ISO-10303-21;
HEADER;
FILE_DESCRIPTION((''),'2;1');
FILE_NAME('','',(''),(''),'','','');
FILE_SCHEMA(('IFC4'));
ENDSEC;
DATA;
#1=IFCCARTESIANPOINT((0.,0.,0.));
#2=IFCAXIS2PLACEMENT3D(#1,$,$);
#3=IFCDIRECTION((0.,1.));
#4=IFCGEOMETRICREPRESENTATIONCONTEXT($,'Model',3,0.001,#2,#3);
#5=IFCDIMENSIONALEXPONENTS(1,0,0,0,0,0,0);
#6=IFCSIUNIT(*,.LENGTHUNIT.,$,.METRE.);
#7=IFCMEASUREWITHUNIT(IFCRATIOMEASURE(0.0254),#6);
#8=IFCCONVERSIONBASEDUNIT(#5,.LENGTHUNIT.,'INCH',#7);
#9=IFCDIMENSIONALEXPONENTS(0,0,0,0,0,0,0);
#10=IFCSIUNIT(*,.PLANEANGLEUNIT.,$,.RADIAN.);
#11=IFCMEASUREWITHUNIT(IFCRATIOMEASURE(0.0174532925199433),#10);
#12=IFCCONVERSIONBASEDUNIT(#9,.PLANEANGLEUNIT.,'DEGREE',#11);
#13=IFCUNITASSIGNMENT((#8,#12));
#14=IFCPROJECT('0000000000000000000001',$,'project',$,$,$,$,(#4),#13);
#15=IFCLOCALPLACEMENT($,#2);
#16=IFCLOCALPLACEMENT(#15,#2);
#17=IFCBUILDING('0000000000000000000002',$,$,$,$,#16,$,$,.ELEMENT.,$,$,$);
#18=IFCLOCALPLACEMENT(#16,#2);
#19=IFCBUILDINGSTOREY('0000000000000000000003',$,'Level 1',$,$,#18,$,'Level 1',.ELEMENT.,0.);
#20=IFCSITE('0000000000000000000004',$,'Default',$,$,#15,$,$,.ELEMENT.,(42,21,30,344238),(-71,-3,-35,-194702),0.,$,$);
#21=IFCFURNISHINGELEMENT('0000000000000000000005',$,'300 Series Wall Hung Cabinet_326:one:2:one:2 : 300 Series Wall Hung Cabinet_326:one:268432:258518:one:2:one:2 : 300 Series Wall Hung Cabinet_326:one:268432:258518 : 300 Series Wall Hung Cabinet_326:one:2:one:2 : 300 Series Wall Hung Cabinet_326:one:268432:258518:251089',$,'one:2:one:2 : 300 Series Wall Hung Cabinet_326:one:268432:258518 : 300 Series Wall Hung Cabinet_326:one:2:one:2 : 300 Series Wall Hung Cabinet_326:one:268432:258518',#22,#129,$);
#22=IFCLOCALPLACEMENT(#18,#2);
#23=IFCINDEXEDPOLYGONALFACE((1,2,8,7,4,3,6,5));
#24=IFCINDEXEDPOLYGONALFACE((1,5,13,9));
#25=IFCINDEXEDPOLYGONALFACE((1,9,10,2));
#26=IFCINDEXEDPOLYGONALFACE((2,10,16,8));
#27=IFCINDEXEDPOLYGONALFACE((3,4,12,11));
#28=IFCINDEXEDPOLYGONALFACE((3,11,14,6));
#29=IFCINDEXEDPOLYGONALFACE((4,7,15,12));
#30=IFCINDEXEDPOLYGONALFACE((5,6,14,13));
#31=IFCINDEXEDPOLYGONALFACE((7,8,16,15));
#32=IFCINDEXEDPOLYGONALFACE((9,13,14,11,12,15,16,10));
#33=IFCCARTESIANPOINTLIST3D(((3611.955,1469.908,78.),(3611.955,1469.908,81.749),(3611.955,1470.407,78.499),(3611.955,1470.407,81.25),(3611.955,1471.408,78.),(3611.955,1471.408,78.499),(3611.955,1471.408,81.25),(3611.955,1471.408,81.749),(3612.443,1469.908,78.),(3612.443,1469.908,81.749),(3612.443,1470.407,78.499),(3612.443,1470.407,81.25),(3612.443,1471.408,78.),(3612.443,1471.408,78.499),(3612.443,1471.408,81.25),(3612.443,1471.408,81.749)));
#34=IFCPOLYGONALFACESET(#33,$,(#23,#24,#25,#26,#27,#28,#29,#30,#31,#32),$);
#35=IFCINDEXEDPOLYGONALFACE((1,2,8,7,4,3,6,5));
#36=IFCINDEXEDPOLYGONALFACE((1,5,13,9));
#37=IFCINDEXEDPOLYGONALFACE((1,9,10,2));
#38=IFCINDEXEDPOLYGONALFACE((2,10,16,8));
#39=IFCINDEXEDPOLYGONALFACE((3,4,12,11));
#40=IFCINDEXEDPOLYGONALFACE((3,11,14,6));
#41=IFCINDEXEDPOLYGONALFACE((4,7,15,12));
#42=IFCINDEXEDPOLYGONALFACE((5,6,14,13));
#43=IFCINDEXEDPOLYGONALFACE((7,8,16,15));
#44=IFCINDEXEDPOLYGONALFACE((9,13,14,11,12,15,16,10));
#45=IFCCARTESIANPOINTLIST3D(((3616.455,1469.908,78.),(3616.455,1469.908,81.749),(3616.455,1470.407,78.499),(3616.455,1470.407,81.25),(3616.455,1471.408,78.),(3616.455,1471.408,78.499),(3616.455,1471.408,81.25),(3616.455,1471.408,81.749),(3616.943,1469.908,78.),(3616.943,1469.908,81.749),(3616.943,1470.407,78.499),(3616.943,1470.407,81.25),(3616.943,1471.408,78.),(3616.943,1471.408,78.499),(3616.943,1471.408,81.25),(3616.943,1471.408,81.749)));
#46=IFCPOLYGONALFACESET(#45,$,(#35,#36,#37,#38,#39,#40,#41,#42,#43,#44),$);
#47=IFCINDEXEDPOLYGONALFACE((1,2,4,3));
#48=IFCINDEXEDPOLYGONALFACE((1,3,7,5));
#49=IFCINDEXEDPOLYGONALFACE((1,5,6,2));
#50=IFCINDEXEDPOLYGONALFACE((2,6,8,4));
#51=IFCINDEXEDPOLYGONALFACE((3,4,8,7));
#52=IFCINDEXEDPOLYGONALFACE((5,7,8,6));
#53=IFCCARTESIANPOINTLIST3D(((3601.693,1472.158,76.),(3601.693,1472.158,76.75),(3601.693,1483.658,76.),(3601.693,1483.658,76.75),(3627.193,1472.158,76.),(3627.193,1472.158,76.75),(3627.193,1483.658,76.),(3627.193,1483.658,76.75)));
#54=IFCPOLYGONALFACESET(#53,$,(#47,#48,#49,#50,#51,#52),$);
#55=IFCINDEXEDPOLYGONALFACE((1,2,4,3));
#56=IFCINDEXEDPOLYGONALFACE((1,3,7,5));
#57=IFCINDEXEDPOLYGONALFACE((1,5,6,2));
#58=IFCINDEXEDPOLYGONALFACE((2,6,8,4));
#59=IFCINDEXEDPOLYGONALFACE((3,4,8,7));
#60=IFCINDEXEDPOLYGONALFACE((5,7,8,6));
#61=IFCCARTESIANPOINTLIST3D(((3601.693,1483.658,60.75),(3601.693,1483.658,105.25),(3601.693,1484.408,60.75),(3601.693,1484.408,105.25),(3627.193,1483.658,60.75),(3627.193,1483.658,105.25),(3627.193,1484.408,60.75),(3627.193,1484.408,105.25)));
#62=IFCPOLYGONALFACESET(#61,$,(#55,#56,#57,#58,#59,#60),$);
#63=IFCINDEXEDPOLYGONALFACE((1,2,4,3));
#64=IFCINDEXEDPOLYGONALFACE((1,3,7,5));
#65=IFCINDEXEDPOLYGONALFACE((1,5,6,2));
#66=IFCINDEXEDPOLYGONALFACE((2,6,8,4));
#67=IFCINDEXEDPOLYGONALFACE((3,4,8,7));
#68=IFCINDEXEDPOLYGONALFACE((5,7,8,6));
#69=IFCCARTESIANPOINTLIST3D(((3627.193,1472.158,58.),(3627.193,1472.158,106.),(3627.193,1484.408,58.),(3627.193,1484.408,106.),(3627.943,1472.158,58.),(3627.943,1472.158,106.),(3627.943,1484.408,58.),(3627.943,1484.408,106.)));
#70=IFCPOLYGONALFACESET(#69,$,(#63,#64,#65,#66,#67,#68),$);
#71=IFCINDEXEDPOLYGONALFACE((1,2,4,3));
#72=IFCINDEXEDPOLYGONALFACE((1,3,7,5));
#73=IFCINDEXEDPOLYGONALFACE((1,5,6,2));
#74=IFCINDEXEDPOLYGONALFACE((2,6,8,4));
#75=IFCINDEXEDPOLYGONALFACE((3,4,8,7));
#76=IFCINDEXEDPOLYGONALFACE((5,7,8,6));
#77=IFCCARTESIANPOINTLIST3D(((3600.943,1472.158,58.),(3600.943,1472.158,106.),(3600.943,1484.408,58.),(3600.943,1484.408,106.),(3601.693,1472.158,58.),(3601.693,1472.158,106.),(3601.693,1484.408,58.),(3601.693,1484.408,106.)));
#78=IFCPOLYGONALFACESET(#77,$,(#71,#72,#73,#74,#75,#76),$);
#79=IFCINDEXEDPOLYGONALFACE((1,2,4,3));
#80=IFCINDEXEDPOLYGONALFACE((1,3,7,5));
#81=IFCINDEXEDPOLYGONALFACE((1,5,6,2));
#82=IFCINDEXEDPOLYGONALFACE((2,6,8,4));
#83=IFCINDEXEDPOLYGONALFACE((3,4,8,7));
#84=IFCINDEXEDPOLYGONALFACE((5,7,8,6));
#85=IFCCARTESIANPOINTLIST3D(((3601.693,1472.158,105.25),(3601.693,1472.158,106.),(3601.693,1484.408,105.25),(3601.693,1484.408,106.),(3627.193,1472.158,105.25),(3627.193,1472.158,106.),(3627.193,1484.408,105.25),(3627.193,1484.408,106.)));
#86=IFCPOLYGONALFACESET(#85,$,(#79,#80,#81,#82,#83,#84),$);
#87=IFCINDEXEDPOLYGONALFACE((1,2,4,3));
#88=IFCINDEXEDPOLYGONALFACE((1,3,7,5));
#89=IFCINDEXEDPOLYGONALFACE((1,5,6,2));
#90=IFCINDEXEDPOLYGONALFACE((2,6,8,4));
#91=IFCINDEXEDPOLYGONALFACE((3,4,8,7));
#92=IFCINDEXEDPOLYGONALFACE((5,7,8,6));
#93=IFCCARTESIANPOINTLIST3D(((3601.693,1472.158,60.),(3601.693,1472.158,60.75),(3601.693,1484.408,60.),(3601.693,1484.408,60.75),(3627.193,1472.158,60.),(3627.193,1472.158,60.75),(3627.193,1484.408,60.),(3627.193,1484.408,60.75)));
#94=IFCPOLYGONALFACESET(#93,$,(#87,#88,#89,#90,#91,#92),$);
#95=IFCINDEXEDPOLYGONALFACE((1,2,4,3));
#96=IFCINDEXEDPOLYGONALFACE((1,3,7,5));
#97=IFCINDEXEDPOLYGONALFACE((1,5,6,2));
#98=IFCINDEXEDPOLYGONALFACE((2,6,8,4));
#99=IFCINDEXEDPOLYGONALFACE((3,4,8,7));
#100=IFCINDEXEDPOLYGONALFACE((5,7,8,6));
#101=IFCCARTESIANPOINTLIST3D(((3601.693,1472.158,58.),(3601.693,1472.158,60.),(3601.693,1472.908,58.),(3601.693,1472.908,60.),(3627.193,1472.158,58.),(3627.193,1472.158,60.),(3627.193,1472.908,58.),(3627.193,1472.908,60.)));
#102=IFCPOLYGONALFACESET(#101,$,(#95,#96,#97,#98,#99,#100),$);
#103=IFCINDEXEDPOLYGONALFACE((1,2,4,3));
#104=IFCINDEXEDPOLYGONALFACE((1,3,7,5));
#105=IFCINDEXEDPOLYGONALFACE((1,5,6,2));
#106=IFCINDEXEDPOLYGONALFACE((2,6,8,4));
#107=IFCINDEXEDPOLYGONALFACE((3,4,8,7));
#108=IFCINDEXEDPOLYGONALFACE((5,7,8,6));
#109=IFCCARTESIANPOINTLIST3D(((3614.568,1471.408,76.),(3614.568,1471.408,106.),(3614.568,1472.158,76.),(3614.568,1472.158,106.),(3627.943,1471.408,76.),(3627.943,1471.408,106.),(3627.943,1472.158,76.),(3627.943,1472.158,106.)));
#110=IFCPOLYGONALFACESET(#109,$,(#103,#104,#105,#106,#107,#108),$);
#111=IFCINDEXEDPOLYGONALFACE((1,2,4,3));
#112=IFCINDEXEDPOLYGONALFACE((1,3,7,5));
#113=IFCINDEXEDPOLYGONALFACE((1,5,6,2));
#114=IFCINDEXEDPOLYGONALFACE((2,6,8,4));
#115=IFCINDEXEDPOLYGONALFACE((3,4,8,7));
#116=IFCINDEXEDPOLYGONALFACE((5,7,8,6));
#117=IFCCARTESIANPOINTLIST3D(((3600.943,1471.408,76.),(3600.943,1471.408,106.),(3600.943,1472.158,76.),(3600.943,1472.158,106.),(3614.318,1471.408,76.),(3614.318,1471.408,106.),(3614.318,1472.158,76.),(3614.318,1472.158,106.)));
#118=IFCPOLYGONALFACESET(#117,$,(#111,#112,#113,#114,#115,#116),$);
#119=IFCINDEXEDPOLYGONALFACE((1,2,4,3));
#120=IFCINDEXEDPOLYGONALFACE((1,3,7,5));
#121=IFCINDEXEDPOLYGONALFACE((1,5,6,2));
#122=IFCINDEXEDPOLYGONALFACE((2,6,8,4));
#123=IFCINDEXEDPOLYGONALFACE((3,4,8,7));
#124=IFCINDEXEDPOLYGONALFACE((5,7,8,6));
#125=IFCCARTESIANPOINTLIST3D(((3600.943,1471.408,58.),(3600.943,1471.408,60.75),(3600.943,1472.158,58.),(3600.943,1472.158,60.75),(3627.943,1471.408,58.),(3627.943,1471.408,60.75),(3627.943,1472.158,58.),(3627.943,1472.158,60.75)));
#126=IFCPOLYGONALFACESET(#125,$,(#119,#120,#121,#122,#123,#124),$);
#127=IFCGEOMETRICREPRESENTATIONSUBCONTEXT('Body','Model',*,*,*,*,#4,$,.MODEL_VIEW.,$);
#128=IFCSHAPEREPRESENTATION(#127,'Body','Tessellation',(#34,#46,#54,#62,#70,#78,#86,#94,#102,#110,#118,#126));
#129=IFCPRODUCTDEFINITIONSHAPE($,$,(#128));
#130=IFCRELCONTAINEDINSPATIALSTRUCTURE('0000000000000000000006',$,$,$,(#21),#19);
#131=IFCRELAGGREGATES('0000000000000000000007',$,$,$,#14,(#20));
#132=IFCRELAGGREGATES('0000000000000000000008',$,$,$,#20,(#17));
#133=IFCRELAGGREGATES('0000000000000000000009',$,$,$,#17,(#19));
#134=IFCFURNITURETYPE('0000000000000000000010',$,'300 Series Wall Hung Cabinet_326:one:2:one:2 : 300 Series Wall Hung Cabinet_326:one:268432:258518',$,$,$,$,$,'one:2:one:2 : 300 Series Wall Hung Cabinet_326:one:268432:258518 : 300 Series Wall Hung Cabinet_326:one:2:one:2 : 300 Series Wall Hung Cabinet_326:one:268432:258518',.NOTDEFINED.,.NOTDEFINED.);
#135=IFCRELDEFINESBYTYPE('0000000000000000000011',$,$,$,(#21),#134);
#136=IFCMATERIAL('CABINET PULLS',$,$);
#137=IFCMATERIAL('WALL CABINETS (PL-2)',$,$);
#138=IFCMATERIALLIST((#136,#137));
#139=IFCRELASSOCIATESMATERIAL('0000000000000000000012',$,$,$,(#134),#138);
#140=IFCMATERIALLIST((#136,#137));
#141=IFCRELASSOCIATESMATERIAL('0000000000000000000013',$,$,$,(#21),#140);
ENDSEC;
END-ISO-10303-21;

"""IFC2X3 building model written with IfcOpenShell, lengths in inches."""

from ifc_helpers import new_model, entity, si_unit, converted_unit, direction, frame, frame_2d, origin, origin_2d_with_axis, place, context, subcontext, project, spatial, polyline, rectangle, outline, extrude, source, transform, mapped, material, material_list, type_object, type_shapes, element, save


model = new_model("IFC2X3")

# Units and contexts
model_context = context("Model", 3, precision=0.001, world=origin(), true_north=direction((0.0, 1.0)))
body_context = subcontext(model_context, "Body", "Model", "MODEL_VIEW")
ifc_project = project(units=[converted_unit("LENGTHUNIT", "INCH", entity("IfcRatioMeasure", 0.0254), si_unit("LENGTHUNIT", "METRE"), dimensions=[1, 0, 0, 0, 0, 0, 0]), converted_unit("PLANEANGLEUNIT", "DEGREE", entity("IfcRatioMeasure", 0.0174532925199433), si_unit("PLANEANGLEUNIT", "RADIAN"), dimensions=[0, 0, 0, 0, 0, 0, 0])], contexts=[model_context])

# Site, building, storey
site_placement = place(None, origin())
site = spatial("IfcSite", under=ifc_project, at=site_placement, Name="Default", CompositionType="ELEMENT", RefLatitude=(42, 21, 30, 344238), RefLongitude=(-71, -3, -35, -194702), RefElevation=0.0)
building_placement = place(site_placement, origin())
building = spatial("IfcBuilding", under=site, at=building_placement, CompositionType="ELEMENT")
storey_placement = place(building_placement, origin())
storey = spatial("IfcBuildingStorey", under=building, at=storey_placement, Name="Level 1", LongName="Level 1", CompositionType="ELEMENT", Elevation=0.0)

# Furnishing element
ifc_material_1 = material(Name="CABINET PULLS")
ifc_material_2 = material(Name="WALL CABINETS (PL-2)")
ifc_material_list_1 = material_list([ifc_material_1, ifc_material_2])
ifc_material_list_2 = material_list([ifc_material_1, ifc_material_2])
furniture_type_1 = type_object("IfcFurnitureType", Name="300 Series Wall Hung Cabinet_326:one:2:one:2 : 300 Series Wall Hung Cabinet_326:one:268432:258518", ElementType="one:2:one:2 : 300 Series Wall Hung Cabinet_326:one:268432:258518 : 300 Series Wall Hung Cabinet_326:one:2:one:2 : 300 Series Wall Hung Cabinet_326:one:268432:258518", AssemblyPlace="NOTDEFINED", material=ifc_material_list_2)
shared_shape_1 = source(origin(), body_context, "Body", "SweptSolid", [
    extrude(outline(polyline([(1.375, -0.625), (1.874, -0.625), (1.874, 0.874), (-1.874, 0.874), (-1.874, -0.625), (-1.375, -0.625), (-1.375, 0.376), (1.375, 0.376), (1.375, -0.625)])), frame((3611.955, 1470.783, 79.874), z_axis=(1.0, 0.0, 0.0), x_axis=(0.0, 0.0, 1.0)), (0.0, 0.0, 1.0), 0.488),
    extrude(outline(polyline([(1.375, -0.625), (1.874, -0.625), (1.874, 0.874), (-1.874, 0.874), (-1.874, -0.625), (-1.375, -0.625), (-1.375, 0.376), (1.375, 0.376), (1.375, -0.625)])), frame((3616.455, 1470.783, 79.874), z_axis=(1.0, 0.0, 0.0), x_axis=(0.0, 0.0, 1.0)), (0.0, 0.0, 1.0), 0.488),
    extrude(rectangle(XDim=25.5, YDim=11.5, at=origin_2d_with_axis()), frame((3614.443, 1477.908, 76.0), z_axis=(0.0, 0.0, 1.0), x_axis=(-1.0, 0.0, 0.0)), (0.0, 0.0, 1.0), 0.75),
    extrude(rectangle(XDim=0.75, YDim=25.5, at=origin_2d_with_axis()), frame((3614.443, 1484.033, 60.75), z_axis=(0.0, 0.0, 1.0), x_axis=(0.0, 1.0, 0.0)), (0.0, 0.0, 1.0), 44.5),
    extrude(rectangle(XDim=0.75, YDim=12.25, at=frame_2d((0.0, 0.0), x_axis=(1.0, 0.0))), frame((3627.568, 1478.283, 58.0)), (0.0, 0.0, 1.0), 48.0),
    extrude(rectangle(XDim=0.75, YDim=12.25, at=frame_2d((0.0, 0.0), x_axis=(1.0, 0.0))), frame((3601.318, 1478.283, 58.0)), (0.0, 0.0, 1.0), 48.0),
    extrude(rectangle(XDim=25.5, YDim=12.25, at=frame_2d((0.0, 0.0), x_axis=(1.0, 0.0))), frame((3614.443, 1478.283, 105.25), z_axis=(0.0, 0.0, 1.0), x_axis=(-1.0, 0.0, 0.0)), (0.0, 0.0, 1.0), 0.75),
    extrude(rectangle(XDim=25.5, YDim=12.25, at=origin_2d_with_axis()), frame((3614.443, 1478.283, 60.0), z_axis=(0.0, 0.0, 1.0), x_axis=(-1.0, 0.0, 0.0)), (0.0, 0.0, 1.0), 0.75),
    extrude(rectangle(XDim=0.75, YDim=25.5, at=origin_2d_with_axis()), frame((3614.443, 1472.533, 58.0), z_axis=(0.0, 0.0, 1.0), x_axis=(0.0, 1.0, 0.0)), (0.0, 0.0, 1.0), 2.0),
    extrude(rectangle(XDim=13.375, YDim=0.75, at=frame_2d((0.0, 0.0), x_axis=(1.0, 0.0))), frame((3621.256, 1471.783, 76.0), z_axis=(0.0, 0.0, 1.0), x_axis=(-1.0, 0.0, 0.0)), (0.0, 0.0, 1.0), 30.0),
    extrude(rectangle(XDim=13.375, YDim=0.75, at=frame_2d((0.0, 0.0), x_axis=(1.0, 0.0))), frame((3607.631, 1471.783, 76.0), z_axis=(0.0, 0.0, 1.0), x_axis=(-1.0, 0.0, 0.0)), (0.0, 0.0, 1.0), 30.0),
    extrude(rectangle(XDim=0.75, YDim=27.0, at=origin_2d_with_axis()), frame((3614.443, 1471.783, 58.0), z_axis=(0.0, 0.0, 1.0), x_axis=(0.0, 1.0, 0.0)), (0.0, 0.0, 1.0), 2.75),
])
type_shapes(furniture_type_1, [shared_shape_1])
furnishing_1_placement = place(storey_placement, origin())
element("IfcFurnishingElement", 1, at=furnishing_1_placement, inside=storey, type_object=furniture_type_1, material=ifc_material_list_1, Name="300 Series Wall Hung Cabinet_326:one:2:one:2 : 300 Series Wall Hung Cabinet_326:one:268432:258518:one:2:one:2 : 300 Series Wall Hung Cabinet_326:one:268432:258518 : 300 Series Wall Hung Cabinet_326:one:2:one:2 : 300 Series Wall Hung Cabinet_326:one:268432:258518:251089", ObjectType="one:2:one:2 : 300 Series Wall Hung Cabinet_326:one:268432:258518 : 300 Series Wall Hung Cabinet_326:one:2:one:2 : 300 Series Wall Hung Cabinet_326:one:268432:258518", context=body_context, shape_type="MappedRepresentation", body=[
    mapped(shared_shape_1, transform((0.0, 0.0, 0.0), scale=1.0)),
])

save(model, "model.ifc")
